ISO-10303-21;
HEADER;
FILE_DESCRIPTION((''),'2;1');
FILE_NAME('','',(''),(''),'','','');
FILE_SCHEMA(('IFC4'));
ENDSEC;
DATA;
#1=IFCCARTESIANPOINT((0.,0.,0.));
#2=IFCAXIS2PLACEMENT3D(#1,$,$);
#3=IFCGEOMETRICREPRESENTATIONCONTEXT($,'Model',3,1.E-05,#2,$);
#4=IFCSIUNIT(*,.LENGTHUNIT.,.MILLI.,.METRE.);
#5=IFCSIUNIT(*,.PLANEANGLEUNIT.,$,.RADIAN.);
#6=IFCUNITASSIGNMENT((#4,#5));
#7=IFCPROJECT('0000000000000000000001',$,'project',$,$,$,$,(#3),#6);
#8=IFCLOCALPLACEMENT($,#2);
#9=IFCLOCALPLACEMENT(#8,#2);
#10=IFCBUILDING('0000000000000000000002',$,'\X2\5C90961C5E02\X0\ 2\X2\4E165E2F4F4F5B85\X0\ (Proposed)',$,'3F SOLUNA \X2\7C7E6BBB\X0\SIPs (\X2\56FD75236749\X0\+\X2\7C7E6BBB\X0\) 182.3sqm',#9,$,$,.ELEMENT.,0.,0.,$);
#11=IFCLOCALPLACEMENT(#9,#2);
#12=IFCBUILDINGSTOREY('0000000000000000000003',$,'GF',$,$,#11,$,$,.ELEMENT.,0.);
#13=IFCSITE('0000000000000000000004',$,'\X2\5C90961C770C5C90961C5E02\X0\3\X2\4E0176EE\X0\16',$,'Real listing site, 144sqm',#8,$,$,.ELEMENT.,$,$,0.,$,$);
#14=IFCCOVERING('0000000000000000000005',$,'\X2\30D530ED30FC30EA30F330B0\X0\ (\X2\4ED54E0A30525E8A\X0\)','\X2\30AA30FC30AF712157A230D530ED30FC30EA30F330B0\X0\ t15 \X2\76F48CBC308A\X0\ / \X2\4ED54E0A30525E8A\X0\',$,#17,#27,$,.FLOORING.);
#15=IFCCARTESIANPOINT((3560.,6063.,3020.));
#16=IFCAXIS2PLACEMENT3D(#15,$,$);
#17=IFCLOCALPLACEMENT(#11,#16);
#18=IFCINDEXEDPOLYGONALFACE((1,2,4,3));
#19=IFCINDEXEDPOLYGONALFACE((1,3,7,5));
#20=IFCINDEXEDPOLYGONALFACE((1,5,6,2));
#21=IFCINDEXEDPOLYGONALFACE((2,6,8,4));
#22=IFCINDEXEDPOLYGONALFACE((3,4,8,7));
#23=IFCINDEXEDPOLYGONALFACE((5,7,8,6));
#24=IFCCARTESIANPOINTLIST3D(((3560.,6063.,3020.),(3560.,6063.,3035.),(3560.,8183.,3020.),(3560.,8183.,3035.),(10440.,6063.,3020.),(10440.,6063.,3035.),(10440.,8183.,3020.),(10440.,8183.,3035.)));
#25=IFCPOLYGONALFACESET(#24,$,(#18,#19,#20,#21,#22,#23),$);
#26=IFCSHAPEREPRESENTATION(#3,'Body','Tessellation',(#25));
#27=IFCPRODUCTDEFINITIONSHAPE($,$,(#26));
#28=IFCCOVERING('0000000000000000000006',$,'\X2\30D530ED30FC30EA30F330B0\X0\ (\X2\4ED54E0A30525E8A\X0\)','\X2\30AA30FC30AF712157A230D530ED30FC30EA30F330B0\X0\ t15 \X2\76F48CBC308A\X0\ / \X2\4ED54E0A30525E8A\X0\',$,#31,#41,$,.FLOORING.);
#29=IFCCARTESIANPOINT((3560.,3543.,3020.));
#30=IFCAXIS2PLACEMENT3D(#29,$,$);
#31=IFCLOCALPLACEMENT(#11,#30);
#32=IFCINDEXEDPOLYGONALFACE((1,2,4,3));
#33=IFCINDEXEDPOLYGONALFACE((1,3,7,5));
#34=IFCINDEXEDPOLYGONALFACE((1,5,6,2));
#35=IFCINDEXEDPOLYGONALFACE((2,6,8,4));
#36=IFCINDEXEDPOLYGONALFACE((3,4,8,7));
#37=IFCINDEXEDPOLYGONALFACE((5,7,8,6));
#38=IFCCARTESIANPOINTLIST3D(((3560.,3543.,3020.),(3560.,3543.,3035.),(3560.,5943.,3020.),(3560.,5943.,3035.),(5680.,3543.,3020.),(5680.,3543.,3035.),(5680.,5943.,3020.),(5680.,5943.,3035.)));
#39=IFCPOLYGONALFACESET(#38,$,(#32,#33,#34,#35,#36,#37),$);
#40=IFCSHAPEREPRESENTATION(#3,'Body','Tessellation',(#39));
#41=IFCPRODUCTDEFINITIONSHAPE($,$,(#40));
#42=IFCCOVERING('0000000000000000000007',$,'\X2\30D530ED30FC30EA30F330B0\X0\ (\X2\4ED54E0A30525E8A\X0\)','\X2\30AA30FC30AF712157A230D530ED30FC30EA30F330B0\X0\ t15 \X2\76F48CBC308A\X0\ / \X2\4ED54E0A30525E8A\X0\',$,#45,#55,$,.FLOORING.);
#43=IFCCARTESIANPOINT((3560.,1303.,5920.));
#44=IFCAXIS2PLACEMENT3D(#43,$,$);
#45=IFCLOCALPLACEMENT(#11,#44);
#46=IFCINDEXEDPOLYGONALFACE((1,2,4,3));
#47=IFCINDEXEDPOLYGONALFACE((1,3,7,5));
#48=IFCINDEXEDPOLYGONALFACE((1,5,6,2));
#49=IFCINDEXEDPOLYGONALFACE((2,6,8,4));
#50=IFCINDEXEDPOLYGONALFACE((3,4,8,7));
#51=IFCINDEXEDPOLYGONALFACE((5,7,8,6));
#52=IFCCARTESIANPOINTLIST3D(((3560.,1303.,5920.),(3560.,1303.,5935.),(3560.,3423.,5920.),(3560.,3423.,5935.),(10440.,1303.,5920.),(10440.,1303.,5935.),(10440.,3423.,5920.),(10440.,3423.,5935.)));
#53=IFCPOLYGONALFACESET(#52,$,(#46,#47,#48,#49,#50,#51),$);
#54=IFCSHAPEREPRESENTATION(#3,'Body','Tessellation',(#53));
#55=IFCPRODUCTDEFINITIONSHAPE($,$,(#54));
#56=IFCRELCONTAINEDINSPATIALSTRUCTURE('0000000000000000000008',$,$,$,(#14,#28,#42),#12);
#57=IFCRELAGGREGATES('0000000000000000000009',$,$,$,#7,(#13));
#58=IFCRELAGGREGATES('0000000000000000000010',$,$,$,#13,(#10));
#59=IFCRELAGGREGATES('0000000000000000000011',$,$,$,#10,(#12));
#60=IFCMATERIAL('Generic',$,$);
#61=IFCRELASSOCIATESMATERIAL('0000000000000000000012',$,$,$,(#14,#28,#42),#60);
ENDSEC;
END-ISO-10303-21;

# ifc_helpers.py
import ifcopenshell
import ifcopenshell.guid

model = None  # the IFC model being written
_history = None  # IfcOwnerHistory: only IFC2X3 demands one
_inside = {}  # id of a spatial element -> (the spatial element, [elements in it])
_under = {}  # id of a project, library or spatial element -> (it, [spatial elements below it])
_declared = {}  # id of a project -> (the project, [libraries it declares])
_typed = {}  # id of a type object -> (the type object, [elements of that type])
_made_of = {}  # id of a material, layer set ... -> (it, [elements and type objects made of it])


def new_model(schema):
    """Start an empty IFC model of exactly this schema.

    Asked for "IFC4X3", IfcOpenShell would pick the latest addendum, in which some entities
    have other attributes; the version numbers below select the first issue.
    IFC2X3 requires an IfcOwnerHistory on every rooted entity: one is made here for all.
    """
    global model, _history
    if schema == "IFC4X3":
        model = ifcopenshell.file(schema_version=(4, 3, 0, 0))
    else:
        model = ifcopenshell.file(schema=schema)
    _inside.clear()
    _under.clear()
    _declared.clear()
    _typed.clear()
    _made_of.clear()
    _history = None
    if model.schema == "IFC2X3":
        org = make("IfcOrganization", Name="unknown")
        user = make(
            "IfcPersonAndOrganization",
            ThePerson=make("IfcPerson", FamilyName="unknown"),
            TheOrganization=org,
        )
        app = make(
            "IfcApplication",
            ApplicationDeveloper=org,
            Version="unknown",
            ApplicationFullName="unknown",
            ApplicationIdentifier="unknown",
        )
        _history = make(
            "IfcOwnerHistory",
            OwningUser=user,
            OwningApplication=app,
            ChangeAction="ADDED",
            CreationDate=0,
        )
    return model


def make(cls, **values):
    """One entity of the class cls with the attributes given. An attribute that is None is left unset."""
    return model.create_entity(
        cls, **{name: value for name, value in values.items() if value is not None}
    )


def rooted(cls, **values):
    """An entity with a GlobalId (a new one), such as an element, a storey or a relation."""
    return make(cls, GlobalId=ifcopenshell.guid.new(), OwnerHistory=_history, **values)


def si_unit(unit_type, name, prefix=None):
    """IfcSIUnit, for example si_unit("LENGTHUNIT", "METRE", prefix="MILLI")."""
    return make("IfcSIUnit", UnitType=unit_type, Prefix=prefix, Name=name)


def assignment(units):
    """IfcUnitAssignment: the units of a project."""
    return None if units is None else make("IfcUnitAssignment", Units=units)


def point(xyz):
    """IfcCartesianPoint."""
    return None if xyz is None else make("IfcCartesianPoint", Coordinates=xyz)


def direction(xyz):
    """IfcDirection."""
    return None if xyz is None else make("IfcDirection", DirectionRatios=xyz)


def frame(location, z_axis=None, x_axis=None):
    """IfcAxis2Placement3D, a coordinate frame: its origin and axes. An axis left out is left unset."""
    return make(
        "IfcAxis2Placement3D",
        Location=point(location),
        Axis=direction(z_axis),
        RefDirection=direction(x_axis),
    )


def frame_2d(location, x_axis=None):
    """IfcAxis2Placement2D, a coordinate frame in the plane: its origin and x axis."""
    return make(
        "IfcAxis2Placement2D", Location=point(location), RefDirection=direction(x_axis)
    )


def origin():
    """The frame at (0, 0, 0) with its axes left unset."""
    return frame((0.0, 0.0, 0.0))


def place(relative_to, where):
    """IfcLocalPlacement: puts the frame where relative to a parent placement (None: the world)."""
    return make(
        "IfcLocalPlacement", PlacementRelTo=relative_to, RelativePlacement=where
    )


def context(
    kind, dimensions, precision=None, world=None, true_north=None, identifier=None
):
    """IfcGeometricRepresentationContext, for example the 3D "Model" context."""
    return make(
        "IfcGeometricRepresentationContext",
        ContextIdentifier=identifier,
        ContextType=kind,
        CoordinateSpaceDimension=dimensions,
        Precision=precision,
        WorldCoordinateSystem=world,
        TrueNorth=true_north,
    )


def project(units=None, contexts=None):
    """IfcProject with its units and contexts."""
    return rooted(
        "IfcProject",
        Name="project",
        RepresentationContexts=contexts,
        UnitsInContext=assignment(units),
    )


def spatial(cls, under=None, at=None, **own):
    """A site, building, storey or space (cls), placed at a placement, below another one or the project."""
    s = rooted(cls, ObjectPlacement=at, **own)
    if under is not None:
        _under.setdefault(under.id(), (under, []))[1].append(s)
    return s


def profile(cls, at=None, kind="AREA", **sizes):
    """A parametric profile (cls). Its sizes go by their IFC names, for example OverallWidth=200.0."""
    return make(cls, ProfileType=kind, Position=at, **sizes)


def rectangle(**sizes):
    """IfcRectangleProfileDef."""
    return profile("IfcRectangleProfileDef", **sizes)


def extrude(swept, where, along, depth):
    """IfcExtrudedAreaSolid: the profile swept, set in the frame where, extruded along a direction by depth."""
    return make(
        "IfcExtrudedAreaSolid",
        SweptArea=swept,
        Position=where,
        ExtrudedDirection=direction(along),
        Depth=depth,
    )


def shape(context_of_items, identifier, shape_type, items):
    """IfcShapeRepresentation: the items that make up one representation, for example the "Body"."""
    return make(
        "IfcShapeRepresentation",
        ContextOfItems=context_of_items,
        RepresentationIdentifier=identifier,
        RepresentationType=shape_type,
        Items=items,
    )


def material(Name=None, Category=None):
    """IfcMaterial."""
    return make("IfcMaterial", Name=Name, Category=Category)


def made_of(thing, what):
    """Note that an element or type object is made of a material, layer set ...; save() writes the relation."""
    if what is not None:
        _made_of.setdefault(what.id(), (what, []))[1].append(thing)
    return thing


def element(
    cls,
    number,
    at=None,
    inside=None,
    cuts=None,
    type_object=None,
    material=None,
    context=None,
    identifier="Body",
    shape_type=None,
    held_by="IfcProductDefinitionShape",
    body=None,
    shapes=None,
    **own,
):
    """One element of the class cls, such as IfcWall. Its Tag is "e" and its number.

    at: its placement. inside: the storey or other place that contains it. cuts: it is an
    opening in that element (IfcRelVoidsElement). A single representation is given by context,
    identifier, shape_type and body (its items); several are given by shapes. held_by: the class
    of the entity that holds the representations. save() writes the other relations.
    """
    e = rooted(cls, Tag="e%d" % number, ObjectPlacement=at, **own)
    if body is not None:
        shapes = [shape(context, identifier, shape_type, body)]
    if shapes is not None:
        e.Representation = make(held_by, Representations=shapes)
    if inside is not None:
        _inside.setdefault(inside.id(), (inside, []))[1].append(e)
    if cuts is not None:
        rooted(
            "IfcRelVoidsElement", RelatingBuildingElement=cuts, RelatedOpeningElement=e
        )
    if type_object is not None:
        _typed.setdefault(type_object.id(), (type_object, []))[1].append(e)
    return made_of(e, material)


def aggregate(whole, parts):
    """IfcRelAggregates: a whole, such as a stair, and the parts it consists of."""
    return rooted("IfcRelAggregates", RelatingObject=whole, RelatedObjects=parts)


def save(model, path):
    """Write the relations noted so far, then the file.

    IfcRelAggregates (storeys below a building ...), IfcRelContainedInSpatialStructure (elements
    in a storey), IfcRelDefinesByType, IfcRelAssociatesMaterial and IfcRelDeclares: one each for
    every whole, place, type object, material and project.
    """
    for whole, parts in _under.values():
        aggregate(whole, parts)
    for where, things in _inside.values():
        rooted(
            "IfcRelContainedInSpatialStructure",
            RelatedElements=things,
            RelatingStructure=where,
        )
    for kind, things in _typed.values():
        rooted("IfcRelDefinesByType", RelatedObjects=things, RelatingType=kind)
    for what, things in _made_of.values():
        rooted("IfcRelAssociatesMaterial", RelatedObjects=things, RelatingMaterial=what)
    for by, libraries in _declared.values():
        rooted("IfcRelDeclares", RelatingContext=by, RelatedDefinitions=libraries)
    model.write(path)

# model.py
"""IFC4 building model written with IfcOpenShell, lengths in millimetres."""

from ifc_helpers import new_model, si_unit, frame, frame_2d, origin, place, context, project, spatial, rectangle, extrude, material, element, save


model = new_model("IFC4")

# Units and contexts
model_context = context("Model", 3, precision=1e-05, world=origin())
ifc_project = project(units=[si_unit("LENGTHUNIT", "METRE", prefix="MILLI"), si_unit("PLANEANGLEUNIT", "RADIAN")], contexts=[model_context])

# Site, building, storey
site_placement = place(None, origin())
site = spatial("IfcSite", under=ifc_project, at=site_placement, Name="岐阜県岐阜市3丁目16", ObjectType="Real listing site, 144sqm", CompositionType="ELEMENT", RefElevation=0.0)
building_placement = place(site_placement, origin())
building = spatial("IfcBuilding", under=site, at=building_placement, Name="岐阜市 2世帯住宅 (Proposed)", ObjectType="3F SOLUNA 籾殻SIPs (国産杉+籾殻) 182.3sqm", CompositionType="ELEMENT", ElevationOfRefHeight=0.0, ElevationOfTerrain=0.0)
storey_placement = place(building_placement, origin())
storey = spatial("IfcBuildingStorey", under=building, at=storey_placement, Name="GF", CompositionType="ELEMENT", Elevation=0.0)

# Shared definitions
ifc_material_1 = material(Name="Generic")

# Coverings
covering_1_placement = place(storey_placement, frame((3560.0, 6063.0, 3020.0)))
element("IfcCovering", 1, at=covering_1_placement, inside=storey, material=ifc_material_1, Name="フローリング (仕上げ床)", Description="オーク無垢フローリング t15 直貼り / 仕上げ床", PredefinedType="FLOORING", context=model_context, shape_type="SweptSolid", body=[
    extrude(rectangle(XDim=6880.0, YDim=2120.0, at=frame_2d((3440.0, 1060.0))), frame((3560.0, 6063.0, 3020.0)), (0.0, 0.0, 1.0), 15.0),
])
covering_2_placement = place(storey_placement, frame((3560.0, 3543.0, 3020.0)))
element("IfcCovering", 2, at=covering_2_placement, inside=storey, material=ifc_material_1, Name="フローリング (仕上げ床)", Description="オーク無垢フローリング t15 直貼り / 仕上げ床", PredefinedType="FLOORING", context=model_context, shape_type="SweptSolid", body=[
    extrude(rectangle(XDim=2120.0, YDim=2400.0, at=frame_2d((1060.0, 1200.0))), frame((3560.0, 3543.0, 3020.0)), (0.0, 0.0, 1.0), 15.0),
])
covering_3_placement = place(storey_placement, frame((3560.0, 1303.0, 5920.0)))
element("IfcCovering", 3, at=covering_3_placement, inside=storey, material=ifc_material_1, Name="フローリング (仕上げ床)", Description="オーク無垢フローリング t15 直貼り / 仕上げ床", PredefinedType="FLOORING", context=model_context, shape_type="SweptSolid", body=[
    extrude(rectangle(XDim=6880.0, YDim=2120.0, at=frame_2d((3440.0, 1060.0))), frame((3560.0, 1303.0, 5920.0)), (0.0, 0.0, 1.0), 15.0),
])

save(model, "model.ifc")
